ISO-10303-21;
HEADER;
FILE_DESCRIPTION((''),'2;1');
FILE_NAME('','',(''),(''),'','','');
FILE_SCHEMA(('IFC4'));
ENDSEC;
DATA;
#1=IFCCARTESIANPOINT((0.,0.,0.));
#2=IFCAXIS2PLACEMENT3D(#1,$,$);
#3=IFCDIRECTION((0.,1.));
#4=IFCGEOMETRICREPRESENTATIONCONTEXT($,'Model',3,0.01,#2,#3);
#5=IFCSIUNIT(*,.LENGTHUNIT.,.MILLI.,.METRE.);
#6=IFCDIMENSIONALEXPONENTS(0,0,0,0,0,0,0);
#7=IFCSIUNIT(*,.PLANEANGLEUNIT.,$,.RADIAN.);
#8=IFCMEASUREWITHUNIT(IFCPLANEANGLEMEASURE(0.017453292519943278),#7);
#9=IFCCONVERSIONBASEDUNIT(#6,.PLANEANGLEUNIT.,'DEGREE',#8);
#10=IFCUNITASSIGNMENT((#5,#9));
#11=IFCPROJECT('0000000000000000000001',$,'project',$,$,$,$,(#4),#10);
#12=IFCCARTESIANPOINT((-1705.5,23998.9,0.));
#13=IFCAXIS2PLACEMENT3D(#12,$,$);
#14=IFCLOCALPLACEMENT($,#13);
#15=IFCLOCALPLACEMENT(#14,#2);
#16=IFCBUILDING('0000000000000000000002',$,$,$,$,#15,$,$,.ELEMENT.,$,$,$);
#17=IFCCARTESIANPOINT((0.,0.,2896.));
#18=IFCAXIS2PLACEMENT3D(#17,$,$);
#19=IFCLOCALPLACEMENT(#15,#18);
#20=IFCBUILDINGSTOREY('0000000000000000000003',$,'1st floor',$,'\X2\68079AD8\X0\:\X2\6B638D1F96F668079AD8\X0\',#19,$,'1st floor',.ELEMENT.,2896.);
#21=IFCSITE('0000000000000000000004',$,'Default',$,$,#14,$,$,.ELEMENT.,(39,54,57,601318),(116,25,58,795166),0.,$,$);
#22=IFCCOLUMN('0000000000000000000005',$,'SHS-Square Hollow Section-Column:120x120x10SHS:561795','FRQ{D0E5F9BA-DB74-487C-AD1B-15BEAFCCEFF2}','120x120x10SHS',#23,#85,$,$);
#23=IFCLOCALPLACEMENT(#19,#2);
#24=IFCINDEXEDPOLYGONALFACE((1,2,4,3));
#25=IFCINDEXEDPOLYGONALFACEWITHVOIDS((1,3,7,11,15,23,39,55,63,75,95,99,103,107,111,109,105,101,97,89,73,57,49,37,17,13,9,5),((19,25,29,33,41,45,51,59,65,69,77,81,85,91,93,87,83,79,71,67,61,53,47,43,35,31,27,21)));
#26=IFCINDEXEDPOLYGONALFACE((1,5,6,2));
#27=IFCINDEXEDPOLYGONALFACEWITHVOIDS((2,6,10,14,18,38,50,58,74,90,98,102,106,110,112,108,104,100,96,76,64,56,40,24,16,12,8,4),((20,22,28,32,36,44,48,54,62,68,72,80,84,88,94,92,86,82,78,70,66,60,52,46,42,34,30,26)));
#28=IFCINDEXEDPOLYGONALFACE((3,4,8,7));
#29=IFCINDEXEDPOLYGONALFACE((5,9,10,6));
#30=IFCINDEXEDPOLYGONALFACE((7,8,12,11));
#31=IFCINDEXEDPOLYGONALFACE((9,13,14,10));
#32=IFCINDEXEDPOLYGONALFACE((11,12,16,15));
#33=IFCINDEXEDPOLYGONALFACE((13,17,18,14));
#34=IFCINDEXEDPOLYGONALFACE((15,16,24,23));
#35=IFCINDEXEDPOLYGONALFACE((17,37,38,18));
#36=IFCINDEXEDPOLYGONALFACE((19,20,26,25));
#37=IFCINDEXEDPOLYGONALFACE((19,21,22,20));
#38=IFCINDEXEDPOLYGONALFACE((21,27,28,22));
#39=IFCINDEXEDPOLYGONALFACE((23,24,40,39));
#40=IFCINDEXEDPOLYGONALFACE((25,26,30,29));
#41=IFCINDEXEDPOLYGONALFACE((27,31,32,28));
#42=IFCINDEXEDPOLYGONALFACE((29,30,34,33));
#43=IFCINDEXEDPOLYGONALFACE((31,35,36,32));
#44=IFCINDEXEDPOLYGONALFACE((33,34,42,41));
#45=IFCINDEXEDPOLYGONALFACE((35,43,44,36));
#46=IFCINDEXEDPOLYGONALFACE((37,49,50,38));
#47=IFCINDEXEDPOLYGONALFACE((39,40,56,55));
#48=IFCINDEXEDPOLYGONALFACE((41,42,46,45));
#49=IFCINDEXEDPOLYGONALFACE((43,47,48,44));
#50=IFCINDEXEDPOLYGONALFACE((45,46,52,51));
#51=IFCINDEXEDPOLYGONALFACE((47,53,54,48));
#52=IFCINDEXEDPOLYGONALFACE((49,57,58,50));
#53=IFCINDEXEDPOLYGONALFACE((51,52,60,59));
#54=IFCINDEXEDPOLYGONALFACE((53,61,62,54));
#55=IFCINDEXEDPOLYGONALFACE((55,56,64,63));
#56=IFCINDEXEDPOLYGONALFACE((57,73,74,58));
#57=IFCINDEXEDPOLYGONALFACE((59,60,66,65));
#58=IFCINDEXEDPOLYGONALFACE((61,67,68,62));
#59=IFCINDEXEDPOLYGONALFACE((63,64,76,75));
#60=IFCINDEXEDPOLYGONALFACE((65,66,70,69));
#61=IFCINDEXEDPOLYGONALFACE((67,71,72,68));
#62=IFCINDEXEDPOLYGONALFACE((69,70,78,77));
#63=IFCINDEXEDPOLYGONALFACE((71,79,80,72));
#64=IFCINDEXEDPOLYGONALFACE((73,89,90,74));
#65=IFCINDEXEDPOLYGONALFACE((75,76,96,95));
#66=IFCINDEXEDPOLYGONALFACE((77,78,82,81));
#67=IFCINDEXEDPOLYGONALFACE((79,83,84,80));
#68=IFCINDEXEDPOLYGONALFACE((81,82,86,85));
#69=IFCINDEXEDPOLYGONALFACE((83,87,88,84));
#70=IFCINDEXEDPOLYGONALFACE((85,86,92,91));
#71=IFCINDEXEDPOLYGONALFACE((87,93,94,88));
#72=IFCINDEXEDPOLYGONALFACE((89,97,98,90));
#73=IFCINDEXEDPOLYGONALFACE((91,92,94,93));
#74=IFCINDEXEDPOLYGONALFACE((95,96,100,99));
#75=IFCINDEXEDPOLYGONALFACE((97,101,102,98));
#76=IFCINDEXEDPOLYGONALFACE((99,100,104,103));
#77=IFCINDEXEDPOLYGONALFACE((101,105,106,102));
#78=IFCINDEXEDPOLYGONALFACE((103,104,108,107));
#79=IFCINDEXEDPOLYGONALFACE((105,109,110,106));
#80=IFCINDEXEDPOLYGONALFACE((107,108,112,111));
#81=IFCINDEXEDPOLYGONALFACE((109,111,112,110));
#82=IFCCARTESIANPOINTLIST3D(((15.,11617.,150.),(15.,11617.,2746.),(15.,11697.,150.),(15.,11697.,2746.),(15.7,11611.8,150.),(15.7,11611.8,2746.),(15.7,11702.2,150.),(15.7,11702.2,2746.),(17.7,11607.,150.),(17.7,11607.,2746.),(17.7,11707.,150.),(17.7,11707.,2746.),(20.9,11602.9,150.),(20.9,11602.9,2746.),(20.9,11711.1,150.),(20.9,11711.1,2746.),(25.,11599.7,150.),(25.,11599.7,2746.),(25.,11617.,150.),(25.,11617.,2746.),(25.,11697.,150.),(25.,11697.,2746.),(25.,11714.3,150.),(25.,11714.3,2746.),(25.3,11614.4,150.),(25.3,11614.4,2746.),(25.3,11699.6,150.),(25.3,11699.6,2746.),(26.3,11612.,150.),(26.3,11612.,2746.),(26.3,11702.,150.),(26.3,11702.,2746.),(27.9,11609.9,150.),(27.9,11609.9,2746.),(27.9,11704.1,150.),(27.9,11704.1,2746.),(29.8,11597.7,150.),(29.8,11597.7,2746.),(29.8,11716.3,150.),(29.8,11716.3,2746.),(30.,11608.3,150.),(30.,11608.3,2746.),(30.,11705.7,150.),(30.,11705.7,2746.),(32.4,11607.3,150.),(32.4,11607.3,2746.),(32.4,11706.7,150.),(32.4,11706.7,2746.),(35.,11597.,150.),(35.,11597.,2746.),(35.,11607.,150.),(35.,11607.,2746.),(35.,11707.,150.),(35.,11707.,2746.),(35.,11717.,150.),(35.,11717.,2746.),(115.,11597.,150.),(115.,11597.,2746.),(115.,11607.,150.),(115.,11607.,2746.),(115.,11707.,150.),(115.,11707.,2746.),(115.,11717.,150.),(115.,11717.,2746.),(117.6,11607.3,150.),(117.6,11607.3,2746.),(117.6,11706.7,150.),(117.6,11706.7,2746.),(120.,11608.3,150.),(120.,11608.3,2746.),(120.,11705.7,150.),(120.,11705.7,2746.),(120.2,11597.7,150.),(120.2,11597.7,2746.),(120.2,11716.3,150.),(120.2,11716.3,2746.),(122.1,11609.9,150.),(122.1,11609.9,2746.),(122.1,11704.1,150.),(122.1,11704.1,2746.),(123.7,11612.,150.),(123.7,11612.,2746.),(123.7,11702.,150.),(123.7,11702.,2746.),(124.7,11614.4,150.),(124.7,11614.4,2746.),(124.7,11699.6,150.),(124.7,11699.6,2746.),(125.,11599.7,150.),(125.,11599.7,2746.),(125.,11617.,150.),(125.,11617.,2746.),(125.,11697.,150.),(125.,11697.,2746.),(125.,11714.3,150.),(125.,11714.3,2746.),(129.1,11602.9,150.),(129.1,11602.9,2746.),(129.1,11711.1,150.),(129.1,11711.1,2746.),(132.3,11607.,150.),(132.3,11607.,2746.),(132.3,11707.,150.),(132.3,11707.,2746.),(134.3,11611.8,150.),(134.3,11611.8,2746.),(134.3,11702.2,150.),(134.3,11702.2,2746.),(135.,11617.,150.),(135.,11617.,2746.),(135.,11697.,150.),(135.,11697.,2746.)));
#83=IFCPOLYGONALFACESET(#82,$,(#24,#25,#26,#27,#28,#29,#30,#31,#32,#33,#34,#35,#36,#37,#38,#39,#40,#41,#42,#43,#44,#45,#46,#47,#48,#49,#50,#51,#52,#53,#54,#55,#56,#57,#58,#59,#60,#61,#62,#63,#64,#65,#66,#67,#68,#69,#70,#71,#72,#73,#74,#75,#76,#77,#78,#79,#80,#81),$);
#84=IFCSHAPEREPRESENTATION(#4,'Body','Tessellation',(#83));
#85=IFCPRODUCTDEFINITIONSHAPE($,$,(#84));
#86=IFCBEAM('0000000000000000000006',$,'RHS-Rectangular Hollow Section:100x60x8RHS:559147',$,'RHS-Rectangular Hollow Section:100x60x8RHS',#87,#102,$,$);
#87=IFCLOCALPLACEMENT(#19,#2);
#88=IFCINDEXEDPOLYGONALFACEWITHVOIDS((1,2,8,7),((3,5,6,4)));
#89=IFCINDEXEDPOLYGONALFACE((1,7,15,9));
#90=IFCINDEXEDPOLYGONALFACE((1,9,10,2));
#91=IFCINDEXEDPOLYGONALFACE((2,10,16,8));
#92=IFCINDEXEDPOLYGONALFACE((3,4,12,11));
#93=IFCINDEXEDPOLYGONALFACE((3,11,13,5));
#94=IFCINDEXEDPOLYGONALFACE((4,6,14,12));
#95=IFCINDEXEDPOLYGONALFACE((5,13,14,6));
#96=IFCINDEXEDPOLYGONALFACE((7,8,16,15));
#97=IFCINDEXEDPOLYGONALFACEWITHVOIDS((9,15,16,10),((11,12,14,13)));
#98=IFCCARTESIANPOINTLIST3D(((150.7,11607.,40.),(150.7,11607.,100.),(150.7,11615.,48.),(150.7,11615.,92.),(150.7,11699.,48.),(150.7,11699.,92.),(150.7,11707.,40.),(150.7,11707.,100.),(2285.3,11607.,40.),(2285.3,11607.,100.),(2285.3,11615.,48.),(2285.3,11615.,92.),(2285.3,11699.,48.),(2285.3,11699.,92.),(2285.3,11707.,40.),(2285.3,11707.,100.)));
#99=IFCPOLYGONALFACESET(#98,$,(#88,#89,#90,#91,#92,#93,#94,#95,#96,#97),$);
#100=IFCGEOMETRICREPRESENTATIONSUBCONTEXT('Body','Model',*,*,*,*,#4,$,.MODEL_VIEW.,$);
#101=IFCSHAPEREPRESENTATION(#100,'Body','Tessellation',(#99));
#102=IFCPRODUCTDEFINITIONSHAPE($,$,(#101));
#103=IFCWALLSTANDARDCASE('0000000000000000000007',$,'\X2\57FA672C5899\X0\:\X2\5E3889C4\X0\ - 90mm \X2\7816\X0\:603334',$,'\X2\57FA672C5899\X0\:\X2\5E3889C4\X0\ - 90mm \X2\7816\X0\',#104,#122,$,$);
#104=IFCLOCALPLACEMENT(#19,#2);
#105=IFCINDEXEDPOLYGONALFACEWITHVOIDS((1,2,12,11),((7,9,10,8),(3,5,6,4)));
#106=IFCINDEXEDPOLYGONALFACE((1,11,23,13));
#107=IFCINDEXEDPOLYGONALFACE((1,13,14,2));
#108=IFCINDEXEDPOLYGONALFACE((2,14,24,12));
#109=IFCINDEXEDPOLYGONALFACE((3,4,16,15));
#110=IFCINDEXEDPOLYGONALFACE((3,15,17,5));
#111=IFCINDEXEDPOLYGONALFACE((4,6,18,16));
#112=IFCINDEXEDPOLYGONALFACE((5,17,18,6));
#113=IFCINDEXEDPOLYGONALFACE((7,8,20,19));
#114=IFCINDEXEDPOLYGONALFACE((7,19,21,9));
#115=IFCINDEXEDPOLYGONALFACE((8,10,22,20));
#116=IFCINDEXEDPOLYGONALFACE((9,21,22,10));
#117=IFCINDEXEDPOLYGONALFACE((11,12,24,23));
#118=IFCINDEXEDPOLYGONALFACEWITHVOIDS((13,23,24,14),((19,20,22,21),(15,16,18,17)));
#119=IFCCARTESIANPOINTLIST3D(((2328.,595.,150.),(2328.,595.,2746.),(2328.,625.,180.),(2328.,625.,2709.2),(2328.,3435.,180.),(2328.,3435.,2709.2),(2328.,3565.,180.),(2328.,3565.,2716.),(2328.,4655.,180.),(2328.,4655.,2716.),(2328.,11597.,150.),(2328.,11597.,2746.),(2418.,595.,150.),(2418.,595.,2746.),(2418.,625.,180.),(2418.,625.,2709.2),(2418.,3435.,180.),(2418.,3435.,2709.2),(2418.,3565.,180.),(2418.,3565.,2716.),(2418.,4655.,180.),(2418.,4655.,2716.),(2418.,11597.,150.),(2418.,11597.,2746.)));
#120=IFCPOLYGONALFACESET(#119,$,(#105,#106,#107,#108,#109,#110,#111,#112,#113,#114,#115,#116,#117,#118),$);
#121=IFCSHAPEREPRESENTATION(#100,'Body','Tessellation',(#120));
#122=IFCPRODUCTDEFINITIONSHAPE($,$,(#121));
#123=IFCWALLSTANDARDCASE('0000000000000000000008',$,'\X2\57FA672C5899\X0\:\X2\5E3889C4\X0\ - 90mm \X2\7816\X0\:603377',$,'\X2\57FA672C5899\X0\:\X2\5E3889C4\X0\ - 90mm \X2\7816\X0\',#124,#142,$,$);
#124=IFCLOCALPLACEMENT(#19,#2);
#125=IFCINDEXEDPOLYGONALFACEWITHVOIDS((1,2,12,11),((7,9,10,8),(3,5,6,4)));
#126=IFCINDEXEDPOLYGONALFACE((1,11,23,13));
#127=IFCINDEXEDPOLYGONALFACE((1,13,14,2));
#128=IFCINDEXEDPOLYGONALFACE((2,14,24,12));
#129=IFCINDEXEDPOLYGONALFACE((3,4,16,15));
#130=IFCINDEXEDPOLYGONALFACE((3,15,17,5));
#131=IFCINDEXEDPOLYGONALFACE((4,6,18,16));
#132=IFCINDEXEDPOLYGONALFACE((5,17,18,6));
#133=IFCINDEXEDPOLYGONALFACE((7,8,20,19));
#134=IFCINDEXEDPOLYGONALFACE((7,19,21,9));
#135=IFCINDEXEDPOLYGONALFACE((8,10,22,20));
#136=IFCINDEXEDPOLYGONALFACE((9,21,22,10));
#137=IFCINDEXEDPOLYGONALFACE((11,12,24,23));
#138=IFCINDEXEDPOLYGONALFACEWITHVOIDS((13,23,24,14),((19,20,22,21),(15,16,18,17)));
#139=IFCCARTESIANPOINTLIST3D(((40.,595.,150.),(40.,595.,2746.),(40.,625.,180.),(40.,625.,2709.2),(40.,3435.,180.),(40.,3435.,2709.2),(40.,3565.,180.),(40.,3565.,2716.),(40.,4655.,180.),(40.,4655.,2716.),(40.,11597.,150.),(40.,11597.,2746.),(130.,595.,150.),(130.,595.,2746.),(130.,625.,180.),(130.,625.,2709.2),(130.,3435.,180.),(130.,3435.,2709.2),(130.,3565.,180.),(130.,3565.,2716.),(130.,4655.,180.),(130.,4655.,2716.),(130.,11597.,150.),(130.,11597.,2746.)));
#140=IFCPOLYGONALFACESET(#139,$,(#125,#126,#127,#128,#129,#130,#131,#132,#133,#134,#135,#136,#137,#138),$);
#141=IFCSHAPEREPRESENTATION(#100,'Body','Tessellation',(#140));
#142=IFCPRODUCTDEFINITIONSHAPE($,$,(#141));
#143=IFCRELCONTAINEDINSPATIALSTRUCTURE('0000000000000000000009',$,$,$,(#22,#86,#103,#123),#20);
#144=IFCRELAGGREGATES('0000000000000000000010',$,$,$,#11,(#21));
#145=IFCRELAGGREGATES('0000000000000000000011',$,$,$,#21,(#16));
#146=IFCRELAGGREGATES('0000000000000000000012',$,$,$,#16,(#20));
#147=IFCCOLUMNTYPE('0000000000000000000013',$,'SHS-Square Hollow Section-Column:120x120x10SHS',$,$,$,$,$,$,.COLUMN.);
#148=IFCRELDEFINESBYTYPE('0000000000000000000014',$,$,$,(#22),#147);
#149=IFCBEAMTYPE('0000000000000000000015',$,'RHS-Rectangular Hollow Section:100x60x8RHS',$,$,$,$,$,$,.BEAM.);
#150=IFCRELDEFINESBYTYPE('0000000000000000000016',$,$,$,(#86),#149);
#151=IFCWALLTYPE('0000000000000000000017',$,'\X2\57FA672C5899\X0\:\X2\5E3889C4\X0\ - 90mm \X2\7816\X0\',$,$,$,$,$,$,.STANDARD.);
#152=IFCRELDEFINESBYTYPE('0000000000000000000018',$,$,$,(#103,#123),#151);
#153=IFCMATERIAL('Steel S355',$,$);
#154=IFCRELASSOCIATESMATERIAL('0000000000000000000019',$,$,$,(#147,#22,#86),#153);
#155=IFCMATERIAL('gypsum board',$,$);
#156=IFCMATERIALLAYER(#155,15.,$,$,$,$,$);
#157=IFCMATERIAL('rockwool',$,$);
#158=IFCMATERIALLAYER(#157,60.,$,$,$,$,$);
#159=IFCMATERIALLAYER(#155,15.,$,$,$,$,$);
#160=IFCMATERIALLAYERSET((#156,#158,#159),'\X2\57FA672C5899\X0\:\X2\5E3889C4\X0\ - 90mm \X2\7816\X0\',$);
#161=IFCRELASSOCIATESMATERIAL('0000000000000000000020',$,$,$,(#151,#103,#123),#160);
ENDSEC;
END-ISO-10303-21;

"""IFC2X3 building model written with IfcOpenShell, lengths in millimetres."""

from ifc_helpers import new_model, entity, si_unit, converted_unit, direction, frame, frame_2d, origin, origin_2d, place, context, subcontext, project, spatial, rectangle, hollow_rectangle, extrude, boolean, clip, halfspace, material, layer, layer_set, layer_usage, type_object, element, save


model = new_model("IFC2X3")

# Units and contexts
model_context = context("Model", 3, precision=0.01, world=origin(), true_north=direction((0.0, 1.0)))
body_context = subcontext(model_context, "Body", "Model", "MODEL_VIEW")
ifc_project = project(units=[si_unit("LENGTHUNIT", "METRE", prefix="MILLI"), converted_unit("PLANEANGLEUNIT", "DEGREE", entity("IfcPlaneAngleMeasure", 0.017453292519943278), si_unit("PLANEANGLEUNIT", "RADIAN"), dimensions=[0, 0, 0, 0, 0, 0, 0])], contexts=[model_context])

# Site, building, storey
site_placement = place(None, frame((-1705.5, 23998.9, 0.0)))
site = spatial("IfcSite", under=ifc_project, at=site_placement, Name="Default", CompositionType="ELEMENT", RefLatitude=(39, 54, 57, 601318), RefLongitude=(116, 25, 58, 795166), RefElevation=0.0)
building_placement = place(site_placement, origin())
building = spatial("IfcBuilding", under=site, at=building_placement, CompositionType="ELEMENT")
storey_placement = place(building_placement, frame((0.0, 0.0, 2896.0)))
storey = spatial("IfcBuildingStorey", under=building, at=storey_placement, Name="1st floor", ObjectType="标高:正负零标高", LongName="1st floor", CompositionType="ELEMENT", Elevation=2896.0)

# Shared definitions
ifc_material_1 = material(Name="Steel S355")

# Column
column_type_1 = type_object("IfcColumnType", Name="SHS-Square Hollow Section-Column:120x120x10SHS", PredefinedType="COLUMN", material=ifc_material_1)
column_1_placement = place(storey_placement, frame((75.0, 11657.0, 2830.9), z_axis=(0.0, 0.0, 1.0), x_axis=(0.0, -1.0, 0.0)))
element("IfcColumn", 1, at=column_1_placement, inside=storey, type_object=column_type_1, material=ifc_material_1, Name="SHS-Square Hollow Section-Column:120x120x10SHS:561795", Description="FRQ{D0E5F9BA-DB74-487C-AD1B-15BEAFCCEFF2}", ObjectType="120x120x10SHS", context=model_context, shape_type="Clipping", body=[
    clip(clip(extrude(hollow_rectangle(XDim=120.0, YDim=120.0, WallThickness=10.0, InnerFilletRadius=10.0, OuterFilletRadius=20.0, at=origin_2d()), origin(), (0.0, 0.0, -1.0), 2765.7), halfspace(frame((11657.0, -75.0, -84.9), z_axis=(0.0, 0.0, -1.0), x_axis=(0.0, -1.0, 0.0)), True)), halfspace(frame((11657.0, -75.0, -2680.9), z_axis=(0.0, 0.0, 1.0), x_axis=(0.0, 1.0, 0.0)), True)),
])

# Beam
beam_type_1 = type_object("IfcBeamType", Name="RHS-Rectangular Hollow Section:100x60x8RHS", PredefinedType="BEAM")
beam_1_placement = place(storey_placement, frame((150.7, 11707.0, 70.0)))
element("IfcBeam", 2, at=beam_1_placement, inside=storey, type_object=beam_type_1, material=ifc_material_1, Name="RHS-Rectangular Hollow Section:100x60x8RHS:559147", ObjectType="RHS-Rectangular Hollow Section:100x60x8RHS", context=body_context, shape_type="SweptSolid", body=[
    boolean("DIFFERENCE", extrude(rectangle(XDim=60.0, YDim=100.0, at=frame_2d((0.0, 0.0), x_axis=(1.0, 0.0))), frame((0.0, -50.0, 0.0), z_axis=(1.0, 0.0, 0.0), x_axis=(0.0, 0.0, -1.0)), (0.0, 0.0, 1.0), 2134.6), extrude(rectangle(XDim=44.0, YDim=84.0, at=frame_2d((0.0, 0.0), x_axis=(0.0, 1.0))), frame((2134.6, -50.0, 0.0), z_axis=(-1.0, 0.0, 0.0), x_axis=(0.0, 1.0, 0.0)), (0.0, 0.0, 1.0), 2134.6)),
])

# Shared definitions
ifc_material_2 = material(Name="gypsum board")
ifc_layer_1 = layer(ifc_material_2, 15.0)
ifc_material_3 = material(Name="rockwool")
ifc_layer_2 = layer(ifc_material_3, 60.0)
ifc_layer_3 = layer(ifc_material_2, 15.0)
ifc_layer_set = layer_set([ifc_layer_1, ifc_layer_2, ifc_layer_3], Name="基本墙:常规 - 90mm 砖")
wall_type = type_object("IfcWallType", Name="基本墙:常规 - 90mm 砖", PredefinedType="STANDARD", material=ifc_layer_set)

# Walls, openings
ifc_layer_usage_1 = layer_usage(ifc_layer_set, "AXIS2", "NEGATIVE", 45.0)
wall_1_placement = place(storey_placement, frame((2373.0, 11597.0, 150.0), z_axis=(0.0, 0.0, 1.0), x_axis=(0.0, -1.0, 0.0)))
wall_1 = element("IfcWallStandardCase", 3, at=wall_1_placement, inside=storey, type_object=wall_type, material=ifc_layer_usage_1, Name="基本墙:常规 - 90mm 砖:603334", ObjectType="基本墙:常规 - 90mm 砖", context=body_context, shape_type="SweptSolid", body=[
    extrude(rectangle(XDim=11002.0, YDim=90.0, at=frame_2d((5501.0, 0.0), x_axis=(-1.0, 0.0))), origin(), (0.0, 0.0, 1.0), 2596.0),
])
opening_1_placement = place(wall_1_placement, origin())
element("IfcOpeningElement", 4, at=opening_1_placement, cuts=wall_1, ObjectType="Opening", context=body_context, shape_type="SweptSolid", body=[
    extrude(rectangle(XDim=2536.0, YDim=1090.0, at=frame_2d((0.0, 0.0), x_axis=(0.0, 1.0))), frame((7487.0, 45.0, 1298.0), z_axis=(0.0, -1.0, 0.0), x_axis=(-1.0, 0.0, 0.0)), (0.0, 0.0, 1.0), 90.0),
])
opening_2_placement = place(wall_1_placement, origin())
element("IfcOpeningElement", 5, at=opening_2_placement, cuts=wall_1, ObjectType="Opening", context=body_context, shape_type="SweptSolid", body=[
    extrude(rectangle(XDim=2529.2, YDim=2810.0, at=frame_2d((0.0, 0.0), x_axis=(0.0, 1.0))), frame((9567.0, 45.0, 1294.6), z_axis=(0.0, -1.0, 0.0), x_axis=(-1.0, 0.0, 0.0)), (0.0, 0.0, 1.0), 90.0),
])
ifc_layer_usage_2 = layer_usage(ifc_layer_set, "AXIS2", "NEGATIVE", 45.0)
wall_2_placement = place(storey_placement, frame((85.0, 11597.0, 150.0), z_axis=(0.0, 0.0, 1.0), x_axis=(0.0, -1.0, 0.0)))
wall_2 = element("IfcWallStandardCase", 6, at=wall_2_placement, inside=storey, type_object=wall_type, material=ifc_layer_usage_2, Name="基本墙:常规 - 90mm 砖:603377", ObjectType="基本墙:常规 - 90mm 砖", context=body_context, shape_type="SweptSolid", body=[
    extrude(rectangle(XDim=11002.0, YDim=90.0, at=frame_2d((5501.0, 0.0), x_axis=(-1.0, 0.0))), origin(), (0.0, 0.0, 1.0), 2596.0),
])
opening_3_placement = place(wall_2_placement, origin())
element("IfcOpeningElement", 7, at=opening_3_placement, cuts=wall_2, ObjectType="Opening", context=body_context, shape_type="SweptSolid", body=[
    extrude(rectangle(XDim=2536.0, YDim=1090.0, at=frame_2d((0.0, 0.0), x_axis=(0.0, 1.0))), frame((7487.0, 45.0, 1298.0), z_axis=(0.0, -1.0, 0.0), x_axis=(-1.0, 0.0, 0.0)), (0.0, 0.0, 1.0), 90.0),
])
opening_4_placement = place(wall_2_placement, origin())
element("IfcOpeningElement", 8, at=opening_4_placement, cuts=wall_2, ObjectType="Opening", context=body_context, shape_type="SweptSolid", body=[
    extrude(rectangle(XDim=2529.2, YDim=2810.0, at=frame_2d((0.0, 0.0), x_axis=(0.0, 1.0))), frame((9567.0, 45.0, 1294.6), z_axis=(0.0, -1.0, 0.0), x_axis=(-1.0, 0.0, 0.0)), (0.0, 0.0, 1.0), 90.0),
])

save(model, "model.ifc")
